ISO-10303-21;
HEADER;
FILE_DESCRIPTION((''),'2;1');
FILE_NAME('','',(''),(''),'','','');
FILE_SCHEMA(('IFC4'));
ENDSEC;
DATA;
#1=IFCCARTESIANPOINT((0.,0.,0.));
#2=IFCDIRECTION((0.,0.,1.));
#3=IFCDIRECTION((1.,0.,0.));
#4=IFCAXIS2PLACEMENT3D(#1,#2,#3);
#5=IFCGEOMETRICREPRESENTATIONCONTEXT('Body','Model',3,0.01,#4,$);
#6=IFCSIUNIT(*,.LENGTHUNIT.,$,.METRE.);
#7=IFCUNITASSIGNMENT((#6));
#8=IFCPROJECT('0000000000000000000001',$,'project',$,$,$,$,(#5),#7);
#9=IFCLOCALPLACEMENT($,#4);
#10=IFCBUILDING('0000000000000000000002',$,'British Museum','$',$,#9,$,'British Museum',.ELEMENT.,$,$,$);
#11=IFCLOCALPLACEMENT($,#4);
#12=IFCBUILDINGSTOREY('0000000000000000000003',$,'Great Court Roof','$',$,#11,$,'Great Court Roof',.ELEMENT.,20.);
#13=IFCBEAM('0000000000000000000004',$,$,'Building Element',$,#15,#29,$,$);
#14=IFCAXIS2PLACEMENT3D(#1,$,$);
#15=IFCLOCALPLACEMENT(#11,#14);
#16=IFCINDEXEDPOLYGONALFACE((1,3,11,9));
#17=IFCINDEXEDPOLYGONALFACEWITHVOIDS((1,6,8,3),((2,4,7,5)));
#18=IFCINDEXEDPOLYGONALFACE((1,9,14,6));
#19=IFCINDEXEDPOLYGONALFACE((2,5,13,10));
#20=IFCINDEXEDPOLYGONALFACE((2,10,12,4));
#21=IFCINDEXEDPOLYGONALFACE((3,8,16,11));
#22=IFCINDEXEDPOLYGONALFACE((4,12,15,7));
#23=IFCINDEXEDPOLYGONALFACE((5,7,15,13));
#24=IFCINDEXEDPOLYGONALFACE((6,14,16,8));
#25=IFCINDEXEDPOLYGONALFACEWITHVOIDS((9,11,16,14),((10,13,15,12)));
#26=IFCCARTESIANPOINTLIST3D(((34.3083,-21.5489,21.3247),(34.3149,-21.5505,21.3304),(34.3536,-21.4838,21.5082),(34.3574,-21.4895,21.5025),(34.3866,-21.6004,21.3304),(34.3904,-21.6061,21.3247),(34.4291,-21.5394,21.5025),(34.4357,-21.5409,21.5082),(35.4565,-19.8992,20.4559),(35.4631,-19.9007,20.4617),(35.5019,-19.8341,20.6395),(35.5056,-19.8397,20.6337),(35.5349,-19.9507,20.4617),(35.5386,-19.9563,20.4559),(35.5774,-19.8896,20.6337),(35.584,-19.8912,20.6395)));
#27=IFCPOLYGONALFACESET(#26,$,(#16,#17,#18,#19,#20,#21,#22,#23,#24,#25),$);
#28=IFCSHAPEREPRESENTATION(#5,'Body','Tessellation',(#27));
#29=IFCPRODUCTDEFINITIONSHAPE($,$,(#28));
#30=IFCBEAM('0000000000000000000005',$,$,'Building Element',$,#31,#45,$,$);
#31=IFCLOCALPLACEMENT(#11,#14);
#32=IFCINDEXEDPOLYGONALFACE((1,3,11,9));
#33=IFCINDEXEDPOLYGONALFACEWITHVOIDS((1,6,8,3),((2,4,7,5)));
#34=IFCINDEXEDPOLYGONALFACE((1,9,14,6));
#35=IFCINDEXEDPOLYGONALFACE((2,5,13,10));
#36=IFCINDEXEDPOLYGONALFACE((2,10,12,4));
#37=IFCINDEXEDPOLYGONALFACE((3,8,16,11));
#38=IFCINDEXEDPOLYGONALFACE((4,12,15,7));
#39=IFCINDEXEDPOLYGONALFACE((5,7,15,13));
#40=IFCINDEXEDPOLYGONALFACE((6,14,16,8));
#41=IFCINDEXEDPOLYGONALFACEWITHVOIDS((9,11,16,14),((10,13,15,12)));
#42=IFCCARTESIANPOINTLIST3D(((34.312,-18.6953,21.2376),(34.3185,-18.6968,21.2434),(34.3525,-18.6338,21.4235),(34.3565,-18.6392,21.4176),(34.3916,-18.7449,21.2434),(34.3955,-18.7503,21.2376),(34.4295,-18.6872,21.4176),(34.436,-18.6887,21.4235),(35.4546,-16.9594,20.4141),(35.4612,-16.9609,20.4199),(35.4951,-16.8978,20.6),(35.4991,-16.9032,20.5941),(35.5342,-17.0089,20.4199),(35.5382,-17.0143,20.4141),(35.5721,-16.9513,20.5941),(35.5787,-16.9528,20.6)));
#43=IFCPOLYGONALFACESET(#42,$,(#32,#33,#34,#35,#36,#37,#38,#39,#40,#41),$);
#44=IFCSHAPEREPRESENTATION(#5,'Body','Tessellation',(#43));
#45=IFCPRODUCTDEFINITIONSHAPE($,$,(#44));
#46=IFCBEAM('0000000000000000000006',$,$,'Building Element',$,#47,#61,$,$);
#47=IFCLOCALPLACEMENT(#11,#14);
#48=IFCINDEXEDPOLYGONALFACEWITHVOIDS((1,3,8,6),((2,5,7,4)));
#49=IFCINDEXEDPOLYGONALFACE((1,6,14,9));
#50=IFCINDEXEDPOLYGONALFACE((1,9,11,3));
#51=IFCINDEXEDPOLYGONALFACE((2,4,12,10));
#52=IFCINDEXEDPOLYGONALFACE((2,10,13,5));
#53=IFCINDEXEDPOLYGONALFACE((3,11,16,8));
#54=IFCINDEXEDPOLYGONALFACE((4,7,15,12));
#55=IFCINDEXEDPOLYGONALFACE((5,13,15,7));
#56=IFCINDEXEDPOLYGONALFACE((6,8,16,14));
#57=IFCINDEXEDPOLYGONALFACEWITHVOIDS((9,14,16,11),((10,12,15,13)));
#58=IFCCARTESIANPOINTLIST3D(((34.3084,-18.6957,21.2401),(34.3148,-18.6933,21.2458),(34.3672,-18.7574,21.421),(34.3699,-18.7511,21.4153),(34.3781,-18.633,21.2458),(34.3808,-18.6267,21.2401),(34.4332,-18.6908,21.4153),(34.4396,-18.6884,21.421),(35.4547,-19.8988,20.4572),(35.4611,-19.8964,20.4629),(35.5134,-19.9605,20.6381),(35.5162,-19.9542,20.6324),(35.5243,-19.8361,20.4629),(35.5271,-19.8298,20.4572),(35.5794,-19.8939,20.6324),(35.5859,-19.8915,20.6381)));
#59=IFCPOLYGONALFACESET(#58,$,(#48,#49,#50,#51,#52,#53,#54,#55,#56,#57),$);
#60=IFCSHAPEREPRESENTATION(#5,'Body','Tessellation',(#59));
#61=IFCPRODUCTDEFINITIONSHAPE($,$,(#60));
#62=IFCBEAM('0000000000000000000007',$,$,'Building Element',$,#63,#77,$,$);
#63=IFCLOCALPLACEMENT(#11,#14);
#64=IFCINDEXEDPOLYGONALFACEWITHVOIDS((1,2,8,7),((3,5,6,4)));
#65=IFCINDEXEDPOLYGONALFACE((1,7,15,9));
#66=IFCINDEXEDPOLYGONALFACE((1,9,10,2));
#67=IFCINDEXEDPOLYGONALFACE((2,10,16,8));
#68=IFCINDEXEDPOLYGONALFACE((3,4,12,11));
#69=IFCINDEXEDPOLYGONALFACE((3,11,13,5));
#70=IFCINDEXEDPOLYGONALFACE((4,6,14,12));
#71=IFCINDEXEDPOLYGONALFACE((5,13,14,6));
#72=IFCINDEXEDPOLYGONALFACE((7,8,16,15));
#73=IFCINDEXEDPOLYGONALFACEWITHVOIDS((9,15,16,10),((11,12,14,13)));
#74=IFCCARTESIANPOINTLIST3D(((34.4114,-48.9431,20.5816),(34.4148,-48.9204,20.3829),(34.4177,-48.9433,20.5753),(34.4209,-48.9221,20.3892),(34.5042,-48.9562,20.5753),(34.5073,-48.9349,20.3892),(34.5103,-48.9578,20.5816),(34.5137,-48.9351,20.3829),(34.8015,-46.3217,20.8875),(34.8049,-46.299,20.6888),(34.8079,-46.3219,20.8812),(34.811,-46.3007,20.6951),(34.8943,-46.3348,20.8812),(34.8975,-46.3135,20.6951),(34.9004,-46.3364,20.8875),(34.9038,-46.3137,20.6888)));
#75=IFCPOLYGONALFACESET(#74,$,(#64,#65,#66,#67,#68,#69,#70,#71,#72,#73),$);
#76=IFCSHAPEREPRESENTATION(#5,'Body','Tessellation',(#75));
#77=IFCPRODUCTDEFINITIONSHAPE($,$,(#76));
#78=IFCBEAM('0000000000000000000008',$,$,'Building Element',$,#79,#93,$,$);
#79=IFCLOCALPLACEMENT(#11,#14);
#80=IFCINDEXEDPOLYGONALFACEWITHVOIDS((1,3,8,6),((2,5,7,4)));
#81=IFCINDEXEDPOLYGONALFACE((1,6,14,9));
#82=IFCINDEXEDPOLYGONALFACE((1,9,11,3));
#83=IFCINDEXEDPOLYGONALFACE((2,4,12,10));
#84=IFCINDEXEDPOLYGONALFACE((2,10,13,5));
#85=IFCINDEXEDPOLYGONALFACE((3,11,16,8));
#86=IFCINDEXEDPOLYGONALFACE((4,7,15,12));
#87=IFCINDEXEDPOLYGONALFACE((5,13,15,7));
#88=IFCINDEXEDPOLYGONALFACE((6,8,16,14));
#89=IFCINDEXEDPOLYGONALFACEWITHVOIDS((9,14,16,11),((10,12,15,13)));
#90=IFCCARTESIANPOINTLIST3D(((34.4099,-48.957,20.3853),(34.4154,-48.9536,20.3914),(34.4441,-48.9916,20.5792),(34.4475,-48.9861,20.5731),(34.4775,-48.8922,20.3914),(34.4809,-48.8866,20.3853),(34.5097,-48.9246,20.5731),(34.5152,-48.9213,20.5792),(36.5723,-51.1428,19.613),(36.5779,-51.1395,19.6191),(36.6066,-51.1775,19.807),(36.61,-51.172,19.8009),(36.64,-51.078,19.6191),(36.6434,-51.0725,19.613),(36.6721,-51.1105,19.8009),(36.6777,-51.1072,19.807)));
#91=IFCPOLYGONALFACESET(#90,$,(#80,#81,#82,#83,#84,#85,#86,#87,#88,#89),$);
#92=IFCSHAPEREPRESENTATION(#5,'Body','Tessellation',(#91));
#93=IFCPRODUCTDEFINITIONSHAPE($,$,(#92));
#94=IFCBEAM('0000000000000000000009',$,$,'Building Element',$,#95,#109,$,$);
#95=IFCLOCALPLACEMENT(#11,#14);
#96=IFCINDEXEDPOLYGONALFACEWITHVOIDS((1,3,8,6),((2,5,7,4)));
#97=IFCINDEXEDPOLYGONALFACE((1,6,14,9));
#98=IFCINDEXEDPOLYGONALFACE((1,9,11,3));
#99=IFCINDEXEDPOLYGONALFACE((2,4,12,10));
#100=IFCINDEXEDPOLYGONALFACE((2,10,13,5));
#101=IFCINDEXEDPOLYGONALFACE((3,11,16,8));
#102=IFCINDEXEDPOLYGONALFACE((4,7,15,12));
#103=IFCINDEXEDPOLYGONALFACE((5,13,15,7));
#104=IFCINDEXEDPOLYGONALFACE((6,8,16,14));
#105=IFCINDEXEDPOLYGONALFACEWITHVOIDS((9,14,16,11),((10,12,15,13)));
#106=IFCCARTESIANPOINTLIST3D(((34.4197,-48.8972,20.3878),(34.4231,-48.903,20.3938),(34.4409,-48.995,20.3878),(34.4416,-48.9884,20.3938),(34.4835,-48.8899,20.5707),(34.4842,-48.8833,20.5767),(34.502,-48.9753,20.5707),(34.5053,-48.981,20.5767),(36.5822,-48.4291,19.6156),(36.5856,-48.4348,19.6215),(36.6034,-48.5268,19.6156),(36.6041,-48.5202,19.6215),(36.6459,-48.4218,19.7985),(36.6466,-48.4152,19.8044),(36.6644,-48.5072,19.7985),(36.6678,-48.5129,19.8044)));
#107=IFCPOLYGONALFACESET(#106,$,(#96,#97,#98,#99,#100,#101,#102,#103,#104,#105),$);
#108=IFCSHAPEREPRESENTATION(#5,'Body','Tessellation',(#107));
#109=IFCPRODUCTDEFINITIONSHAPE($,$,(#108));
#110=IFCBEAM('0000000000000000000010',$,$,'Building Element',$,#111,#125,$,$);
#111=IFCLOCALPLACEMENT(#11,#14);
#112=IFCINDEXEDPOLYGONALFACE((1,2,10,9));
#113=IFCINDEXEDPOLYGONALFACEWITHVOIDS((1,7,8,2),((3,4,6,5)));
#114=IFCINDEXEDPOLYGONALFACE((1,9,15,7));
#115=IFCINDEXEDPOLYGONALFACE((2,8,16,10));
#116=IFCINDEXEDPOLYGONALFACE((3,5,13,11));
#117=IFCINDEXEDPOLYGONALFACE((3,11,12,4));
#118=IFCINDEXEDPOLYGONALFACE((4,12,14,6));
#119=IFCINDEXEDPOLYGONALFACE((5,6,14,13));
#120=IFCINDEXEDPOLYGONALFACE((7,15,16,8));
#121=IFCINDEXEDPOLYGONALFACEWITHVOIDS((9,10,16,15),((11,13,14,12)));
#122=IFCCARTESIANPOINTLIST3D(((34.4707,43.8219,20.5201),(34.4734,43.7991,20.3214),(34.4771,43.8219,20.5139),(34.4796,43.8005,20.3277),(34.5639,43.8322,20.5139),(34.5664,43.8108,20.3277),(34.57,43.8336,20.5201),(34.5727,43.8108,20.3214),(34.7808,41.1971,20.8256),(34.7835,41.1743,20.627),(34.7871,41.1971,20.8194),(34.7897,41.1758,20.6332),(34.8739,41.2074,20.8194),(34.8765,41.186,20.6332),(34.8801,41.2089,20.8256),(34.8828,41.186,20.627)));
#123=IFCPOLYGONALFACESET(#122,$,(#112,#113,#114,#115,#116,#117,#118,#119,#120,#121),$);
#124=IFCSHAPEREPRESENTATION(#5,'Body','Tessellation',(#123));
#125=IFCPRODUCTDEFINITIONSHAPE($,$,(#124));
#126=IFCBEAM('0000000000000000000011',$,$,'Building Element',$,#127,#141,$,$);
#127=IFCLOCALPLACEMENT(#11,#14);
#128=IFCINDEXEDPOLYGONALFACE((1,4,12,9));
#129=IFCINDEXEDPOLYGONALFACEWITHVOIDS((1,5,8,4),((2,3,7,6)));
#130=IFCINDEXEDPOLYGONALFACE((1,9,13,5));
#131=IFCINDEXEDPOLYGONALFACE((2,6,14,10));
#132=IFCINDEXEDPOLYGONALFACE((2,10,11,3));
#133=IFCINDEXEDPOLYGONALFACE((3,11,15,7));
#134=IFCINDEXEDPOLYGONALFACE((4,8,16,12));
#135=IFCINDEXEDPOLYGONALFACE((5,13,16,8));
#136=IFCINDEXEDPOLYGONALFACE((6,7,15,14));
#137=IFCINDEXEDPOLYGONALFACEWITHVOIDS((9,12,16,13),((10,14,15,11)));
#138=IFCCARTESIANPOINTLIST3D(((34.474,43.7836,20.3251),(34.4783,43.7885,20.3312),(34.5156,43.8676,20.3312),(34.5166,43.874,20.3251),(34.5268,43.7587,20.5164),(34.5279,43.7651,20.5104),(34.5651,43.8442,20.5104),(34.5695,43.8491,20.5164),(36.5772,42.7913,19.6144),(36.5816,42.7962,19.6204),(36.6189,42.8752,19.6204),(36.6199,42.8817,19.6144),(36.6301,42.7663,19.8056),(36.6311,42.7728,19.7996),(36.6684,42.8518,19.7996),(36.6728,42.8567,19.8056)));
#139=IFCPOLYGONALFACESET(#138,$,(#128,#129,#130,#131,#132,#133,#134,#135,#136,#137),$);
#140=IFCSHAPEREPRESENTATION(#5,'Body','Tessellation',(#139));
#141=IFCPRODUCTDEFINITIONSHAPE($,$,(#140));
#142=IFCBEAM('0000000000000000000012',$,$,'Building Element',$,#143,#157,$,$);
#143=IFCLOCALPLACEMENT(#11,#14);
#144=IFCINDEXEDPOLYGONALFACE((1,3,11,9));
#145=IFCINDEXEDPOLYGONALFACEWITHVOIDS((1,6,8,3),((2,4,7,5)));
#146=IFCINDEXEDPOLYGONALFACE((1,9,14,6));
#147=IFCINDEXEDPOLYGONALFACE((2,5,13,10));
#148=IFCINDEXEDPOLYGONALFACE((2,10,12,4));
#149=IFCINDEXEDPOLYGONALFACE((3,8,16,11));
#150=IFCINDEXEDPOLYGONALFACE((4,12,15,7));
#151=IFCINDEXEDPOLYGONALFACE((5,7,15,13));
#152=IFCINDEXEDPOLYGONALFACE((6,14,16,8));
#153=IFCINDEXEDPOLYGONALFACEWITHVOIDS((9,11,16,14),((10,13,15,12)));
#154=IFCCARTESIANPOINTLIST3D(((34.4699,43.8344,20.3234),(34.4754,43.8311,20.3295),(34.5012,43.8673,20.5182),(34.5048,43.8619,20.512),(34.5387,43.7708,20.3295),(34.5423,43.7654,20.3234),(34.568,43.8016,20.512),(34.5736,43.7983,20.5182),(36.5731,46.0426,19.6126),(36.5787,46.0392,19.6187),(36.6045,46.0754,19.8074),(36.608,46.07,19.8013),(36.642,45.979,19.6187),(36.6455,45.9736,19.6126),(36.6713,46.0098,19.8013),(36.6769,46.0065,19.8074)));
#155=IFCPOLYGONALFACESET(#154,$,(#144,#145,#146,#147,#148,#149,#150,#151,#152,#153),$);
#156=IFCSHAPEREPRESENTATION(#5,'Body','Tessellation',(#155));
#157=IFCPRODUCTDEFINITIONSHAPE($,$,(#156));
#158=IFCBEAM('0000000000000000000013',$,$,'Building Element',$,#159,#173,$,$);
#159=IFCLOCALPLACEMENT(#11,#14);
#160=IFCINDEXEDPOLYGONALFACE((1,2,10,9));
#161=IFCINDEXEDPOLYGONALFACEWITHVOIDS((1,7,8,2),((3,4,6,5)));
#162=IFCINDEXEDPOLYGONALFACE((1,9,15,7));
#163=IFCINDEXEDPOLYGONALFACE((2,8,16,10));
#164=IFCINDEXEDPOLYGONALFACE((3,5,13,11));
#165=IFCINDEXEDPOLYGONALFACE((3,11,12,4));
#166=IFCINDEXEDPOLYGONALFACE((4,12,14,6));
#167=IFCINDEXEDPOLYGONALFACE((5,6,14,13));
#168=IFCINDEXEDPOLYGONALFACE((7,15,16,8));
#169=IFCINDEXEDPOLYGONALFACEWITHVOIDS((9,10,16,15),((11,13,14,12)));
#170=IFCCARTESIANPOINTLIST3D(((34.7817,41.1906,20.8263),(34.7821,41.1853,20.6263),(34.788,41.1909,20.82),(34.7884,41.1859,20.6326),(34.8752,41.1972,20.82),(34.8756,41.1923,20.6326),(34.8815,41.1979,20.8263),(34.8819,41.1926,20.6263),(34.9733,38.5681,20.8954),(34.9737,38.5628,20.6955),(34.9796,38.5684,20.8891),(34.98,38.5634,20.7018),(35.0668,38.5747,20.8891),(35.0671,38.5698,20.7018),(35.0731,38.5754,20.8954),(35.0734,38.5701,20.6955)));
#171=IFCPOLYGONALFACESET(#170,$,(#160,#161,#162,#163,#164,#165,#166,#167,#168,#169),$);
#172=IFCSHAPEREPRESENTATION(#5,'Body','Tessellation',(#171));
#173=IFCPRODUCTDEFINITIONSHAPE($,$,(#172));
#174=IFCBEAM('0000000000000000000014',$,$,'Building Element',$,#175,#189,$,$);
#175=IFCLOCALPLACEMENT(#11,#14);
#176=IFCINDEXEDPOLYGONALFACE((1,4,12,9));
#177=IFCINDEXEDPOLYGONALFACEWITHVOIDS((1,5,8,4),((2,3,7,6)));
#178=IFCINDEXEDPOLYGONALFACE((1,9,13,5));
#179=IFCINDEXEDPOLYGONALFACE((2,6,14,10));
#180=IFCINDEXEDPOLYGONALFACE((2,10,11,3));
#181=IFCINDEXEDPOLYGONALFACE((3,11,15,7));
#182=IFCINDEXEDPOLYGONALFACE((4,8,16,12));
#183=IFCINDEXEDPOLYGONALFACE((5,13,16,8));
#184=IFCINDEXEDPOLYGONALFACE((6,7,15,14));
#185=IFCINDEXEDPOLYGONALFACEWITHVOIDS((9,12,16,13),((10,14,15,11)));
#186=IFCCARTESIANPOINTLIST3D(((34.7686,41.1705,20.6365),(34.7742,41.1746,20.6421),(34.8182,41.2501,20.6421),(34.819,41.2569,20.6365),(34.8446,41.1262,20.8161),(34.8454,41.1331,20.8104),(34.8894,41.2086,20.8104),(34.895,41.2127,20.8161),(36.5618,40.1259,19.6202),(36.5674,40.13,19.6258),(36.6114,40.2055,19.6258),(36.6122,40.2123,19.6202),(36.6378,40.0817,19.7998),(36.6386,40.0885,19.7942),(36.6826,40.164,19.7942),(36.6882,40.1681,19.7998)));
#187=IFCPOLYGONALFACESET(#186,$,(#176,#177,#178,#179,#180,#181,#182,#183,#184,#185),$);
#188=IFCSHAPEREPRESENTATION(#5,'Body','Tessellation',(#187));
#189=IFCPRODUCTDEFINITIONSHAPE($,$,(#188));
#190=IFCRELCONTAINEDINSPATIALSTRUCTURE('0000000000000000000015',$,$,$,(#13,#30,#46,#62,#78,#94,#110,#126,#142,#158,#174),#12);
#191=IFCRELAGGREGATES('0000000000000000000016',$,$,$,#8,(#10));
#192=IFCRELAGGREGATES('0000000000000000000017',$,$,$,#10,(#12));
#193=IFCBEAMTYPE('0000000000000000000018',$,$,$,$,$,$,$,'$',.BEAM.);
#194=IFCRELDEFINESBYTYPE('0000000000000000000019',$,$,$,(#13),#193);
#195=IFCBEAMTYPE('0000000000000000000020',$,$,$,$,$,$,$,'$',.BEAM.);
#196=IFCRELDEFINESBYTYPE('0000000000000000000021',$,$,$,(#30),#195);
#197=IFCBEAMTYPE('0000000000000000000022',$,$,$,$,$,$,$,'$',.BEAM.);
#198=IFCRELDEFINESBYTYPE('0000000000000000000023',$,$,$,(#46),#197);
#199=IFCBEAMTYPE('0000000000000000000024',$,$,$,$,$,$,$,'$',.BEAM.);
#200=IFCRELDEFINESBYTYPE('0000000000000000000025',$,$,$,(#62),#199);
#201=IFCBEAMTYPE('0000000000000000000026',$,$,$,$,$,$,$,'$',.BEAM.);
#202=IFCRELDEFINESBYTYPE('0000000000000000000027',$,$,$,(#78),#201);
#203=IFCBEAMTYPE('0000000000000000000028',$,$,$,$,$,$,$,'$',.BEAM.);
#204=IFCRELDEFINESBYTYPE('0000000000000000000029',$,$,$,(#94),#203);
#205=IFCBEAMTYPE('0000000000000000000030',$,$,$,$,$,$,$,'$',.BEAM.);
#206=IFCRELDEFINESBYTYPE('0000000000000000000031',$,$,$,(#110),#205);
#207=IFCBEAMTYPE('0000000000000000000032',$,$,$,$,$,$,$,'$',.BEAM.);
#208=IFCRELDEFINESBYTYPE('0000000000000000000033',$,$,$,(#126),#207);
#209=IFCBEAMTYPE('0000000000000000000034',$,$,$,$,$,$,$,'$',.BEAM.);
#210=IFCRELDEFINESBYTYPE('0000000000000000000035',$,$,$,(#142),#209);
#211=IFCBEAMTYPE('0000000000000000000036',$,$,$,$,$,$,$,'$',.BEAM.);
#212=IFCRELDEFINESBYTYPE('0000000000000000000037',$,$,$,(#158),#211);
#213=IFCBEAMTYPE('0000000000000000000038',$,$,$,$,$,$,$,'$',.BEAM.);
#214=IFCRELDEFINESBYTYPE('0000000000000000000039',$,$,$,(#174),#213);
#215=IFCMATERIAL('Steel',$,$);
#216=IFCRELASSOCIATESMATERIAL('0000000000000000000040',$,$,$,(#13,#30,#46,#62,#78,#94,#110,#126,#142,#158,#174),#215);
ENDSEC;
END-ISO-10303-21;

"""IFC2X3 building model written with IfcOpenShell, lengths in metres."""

from ifc_helpers import new_model, si_unit, frame, origin_with_axes, origin_2d, place, context, project, spatial, hollow_rectangle, extrude, material, type_object, element, save


model = new_model("IFC2X3")

# Units and contexts
model_context = context("Model", 3, precision=0.01, world=origin_with_axes(), identifier="Body")
ifc_project = project(units=[si_unit("LENGTHUNIT", "METRE")], contexts=[model_context])

# Building, storey
building_placement = place(None, origin_with_axes())
building = spatial("IfcBuilding", under=ifc_project, at=building_placement, Name="British Museum", Description="$", LongName="British Museum", CompositionType="ELEMENT")
storey_placement = place(None, origin_with_axes())
storey = spatial("IfcBuildingStorey", under=building, at=storey_placement, Name="Great Court Roof", Description="$", LongName="Great Court Roof", CompositionType="ELEMENT", Elevation=20.0)

# Beams
ifc_material = material(Name="Steel")
beam_type_1 = type_object("IfcBeamType", ElementType="$", PredefinedType="BEAM")
beam_1_placement = place(None, origin_with_axes())
element("IfcBeam", 1, at=beam_1_placement, inside=storey, type_object=beam_type_1, material=ifc_material, Description="Building Element", context=model_context, shape_type="SweptSolid", body=[
    extrude(hollow_rectangle(XDim=0.1, YDim=0.2, WallThickness=0.0063, InnerFilletRadius=0.0, OuterFilletRadius=0.0, at=origin_2d()), frame((34.372, -21.5449, 21.4164), z_axis=(0.524373, 0.753405, -0.396754), x_axis=(-0.82077, 0.571259, 0.0)), (0.0, 0.0, 1.0), 2.1897),
])
beam_type_2 = type_object("IfcBeamType", ElementType="$", PredefinedType="BEAM")
beam_2_placement = place(None, origin_with_axes())
element("IfcBeam", 2, at=beam_2_placement, inside=storey, type_object=beam_type_2, material=ifc_material, Description="Building Element", context=model_context, shape_type="SweptSolid", body=[
    extrude(hollow_rectangle(XDim=0.1, YDim=0.2, WallThickness=0.0063, InnerFilletRadius=0.0, OuterFilletRadius=0.0, at=origin_2d()), frame((34.374, -18.692, 21.3305), z_axis=(0.511137, 0.776554, -0.368379), x_axis=(-0.835295, 0.549802, 0.0)), (0.0, 0.0, 1.0), 2.2354),
])
beam_type_3 = type_object("IfcBeamType", ElementType="$", PredefinedType="BEAM")
beam_3_placement = place(None, origin_with_axes())
element("IfcBeam", 3, at=beam_3_placement, inside=storey, type_object=beam_type_3, material=ifc_material, Description="Building Element", context=model_context, shape_type="SweptSolid", body=[
    extrude(hollow_rectangle(XDim=0.1, YDim=0.2, WallThickness=0.0063, InnerFilletRadius=0.0, OuterFilletRadius=0.0, at=origin_2d()), frame((34.374, -18.692, 21.3305), z_axis=(0.623992, -0.654984, -0.426181), x_axis=(0.724029, 0.68977, 0.0)), (0.0, 0.0, 1.0), 1.8369),
])
beam_type_4 = type_object("IfcBeamType", ElementType="$", PredefinedType="BEAM")
beam_4_placement = place(None, origin_with_axes())
element("IfcBeam", 4, at=beam_4_placement, inside=storey, type_object=beam_type_4, material=ifc_material, Description="Building Element", context=model_context, shape_type="SweptSolid", body=[
    extrude(hollow_rectangle(XDim=0.1, YDim=0.2, WallThickness=0.0063, InnerFilletRadius=0.0, OuterFilletRadius=0.0, at=origin_2d()), frame((34.4625, -48.9391, 20.4822), z_axis=(0.146239, 0.982582, 0.114658), x_axis=(-0.989105, 0.14721, 0.0)), (0.0, 0.0, 1.0), 2.6679),
])
beam_type_5 = type_object("IfcBeamType", ElementType="$", PredefinedType="BEAM")
beam_5_placement = place(None, origin_with_axes())
element("IfcBeam", 5, at=beam_5_placement, inside=storey, type_object=beam_type_5, material=ifc_material, Description="Building Element", context=model_context, shape_type="SweptSolid", body=[
    extrude(hollow_rectangle(XDim=0.1, YDim=0.2, WallThickness=0.0063, InnerFilletRadius=0.0, OuterFilletRadius=0.0, at=origin_2d()), frame((34.4625, -48.9391, 20.4822), z_axis=(0.682107, -0.689489, -0.24359), x_axis=(0.710902, 0.703291, 0.0)), (0.0, 0.0, 1.0), 3.1703),
])
beam_type_6 = type_object("IfcBeamType", ElementType="$", PredefinedType="BEAM")
beam_6_placement = place(None, origin_with_axes())
element("IfcBeam", 6, at=beam_6_placement, inside=storey, type_object=beam_type_6, material=ifc_material, Description="Building Element", context=model_context, shape_type="SweptSolid", body=[
    extrude(hollow_rectangle(XDim=0.1, YDim=0.2, WallThickness=0.0063, InnerFilletRadius=0.0, OuterFilletRadius=0.0, at=origin_2d()), frame((34.4625, -48.9391, 20.4822), z_axis=(0.922769, 0.19976, -0.329534), x_axis=(-0.211578, 0.977361, 0.0)), (0.0, 0.0, 1.0), 2.3435),
])
beam_type_7 = type_object("IfcBeamType", ElementType="$", PredefinedType="BEAM")
beam_7_placement = place(None, origin_with_axes())
element("IfcBeam", 7, at=beam_7_placement, inside=storey, type_object=beam_type_7, material=ifc_material, Description="Building Element", context=model_context, shape_type="SweptSolid", body=[
    extrude(hollow_rectangle(XDim=0.1, YDim=0.2, WallThickness=0.0063, InnerFilletRadius=0.0, OuterFilletRadius=0.0, at=origin_2d()), frame((34.5217, 43.8164, 20.4208), z_axis=(0.116539, -0.986526, 0.114828), x_axis=(0.993095, 0.117315, 0.0)), (0.0, 0.0, 1.0), 2.6606),
])
beam_type_8 = type_object("IfcBeamType", ElementType="$", PredefinedType="BEAM")
beam_8_placement = place(None, origin_with_axes())
element("IfcBeam", 8, at=beam_8_placement, inside=storey, type_object=beam_type_8, material=ifc_material, Description="Building Element", context=model_context, shape_type="SweptSolid", body=[
    extrude(hollow_rectangle(XDim=0.1, YDim=0.2, WallThickness=0.0063, InnerFilletRadius=0.0, OuterFilletRadius=0.0, at=origin_2d()), frame((34.5217, 43.8164, 20.4208), z_axis=(0.864897, -0.408072, -0.292285), x_axis=(0.426706, 0.904391, 0.0)), (0.0, 0.0, 1.0), 2.4318),
])
beam_type_9 = type_object("IfcBeamType", ElementType="$", PredefinedType="BEAM")
beam_9_placement = place(None, origin_with_axes())
element("IfcBeam", 9, at=beam_9_placement, inside=storey, type_object=beam_type_9, material=ifc_material, Description="Building Element", context=model_context, shape_type="SweptSolid", body=[
    extrude(hollow_rectangle(XDim=0.1, YDim=0.2, WallThickness=0.0063, InnerFilletRadius=0.0, OuterFilletRadius=0.0, at=origin_2d()), frame((34.5217, 43.8164, 20.4208), z_axis=(0.671699, 0.705191, -0.226995), x_axis=(-0.724093, 0.689703, 0.0)), (0.0, 0.0, 1.0), 3.1313),
])
beam_type_10 = type_object("IfcBeamType", ElementType="$", PredefinedType="BEAM")
beam_10_placement = place(None, origin_with_axes())
element("IfcBeam", 10, at=beam_10_placement, inside=storey, type_object=beam_type_10, material=ifc_material, Description="Building Element", context=model_context, shape_type="SweptSolid", body=[
    extrude(hollow_rectangle(XDim=0.1, YDim=0.2, WallThickness=0.0063, InnerFilletRadius=0.0, OuterFilletRadius=0.0, at=origin_2d()), frame((34.8318, 41.1916, 20.7263), z_axis=(0.072834, -0.996997, 0.026302), x_axis=(0.997342, 0.072859, 0.0)), (0.0, 0.0, 1.0), 2.6304),
])
beam_type_11 = type_object("IfcBeamType", ElementType="$", PredefinedType="BEAM")
beam_11_placement = place(None, origin_with_axes())
element("IfcBeam", 11, at=beam_11_placement, inside=storey, type_object=beam_type_11, material=ifc_material, Description="Building Element", context=model_context, shape_type="SweptSolid", body=[
    extrude(hollow_rectangle(XDim=0.1, YDim=0.2, WallThickness=0.0063, InnerFilletRadius=0.0, OuterFilletRadius=0.0, at=origin_2d()), frame((34.8318, 41.1916, 20.7263), z_axis=(0.776024, -0.452054, -0.439811), x_axis=(0.50335, 0.864083, 0.0)), (0.0, 0.0, 1.0), 2.3108),
])

save(model, "model.ifc")
